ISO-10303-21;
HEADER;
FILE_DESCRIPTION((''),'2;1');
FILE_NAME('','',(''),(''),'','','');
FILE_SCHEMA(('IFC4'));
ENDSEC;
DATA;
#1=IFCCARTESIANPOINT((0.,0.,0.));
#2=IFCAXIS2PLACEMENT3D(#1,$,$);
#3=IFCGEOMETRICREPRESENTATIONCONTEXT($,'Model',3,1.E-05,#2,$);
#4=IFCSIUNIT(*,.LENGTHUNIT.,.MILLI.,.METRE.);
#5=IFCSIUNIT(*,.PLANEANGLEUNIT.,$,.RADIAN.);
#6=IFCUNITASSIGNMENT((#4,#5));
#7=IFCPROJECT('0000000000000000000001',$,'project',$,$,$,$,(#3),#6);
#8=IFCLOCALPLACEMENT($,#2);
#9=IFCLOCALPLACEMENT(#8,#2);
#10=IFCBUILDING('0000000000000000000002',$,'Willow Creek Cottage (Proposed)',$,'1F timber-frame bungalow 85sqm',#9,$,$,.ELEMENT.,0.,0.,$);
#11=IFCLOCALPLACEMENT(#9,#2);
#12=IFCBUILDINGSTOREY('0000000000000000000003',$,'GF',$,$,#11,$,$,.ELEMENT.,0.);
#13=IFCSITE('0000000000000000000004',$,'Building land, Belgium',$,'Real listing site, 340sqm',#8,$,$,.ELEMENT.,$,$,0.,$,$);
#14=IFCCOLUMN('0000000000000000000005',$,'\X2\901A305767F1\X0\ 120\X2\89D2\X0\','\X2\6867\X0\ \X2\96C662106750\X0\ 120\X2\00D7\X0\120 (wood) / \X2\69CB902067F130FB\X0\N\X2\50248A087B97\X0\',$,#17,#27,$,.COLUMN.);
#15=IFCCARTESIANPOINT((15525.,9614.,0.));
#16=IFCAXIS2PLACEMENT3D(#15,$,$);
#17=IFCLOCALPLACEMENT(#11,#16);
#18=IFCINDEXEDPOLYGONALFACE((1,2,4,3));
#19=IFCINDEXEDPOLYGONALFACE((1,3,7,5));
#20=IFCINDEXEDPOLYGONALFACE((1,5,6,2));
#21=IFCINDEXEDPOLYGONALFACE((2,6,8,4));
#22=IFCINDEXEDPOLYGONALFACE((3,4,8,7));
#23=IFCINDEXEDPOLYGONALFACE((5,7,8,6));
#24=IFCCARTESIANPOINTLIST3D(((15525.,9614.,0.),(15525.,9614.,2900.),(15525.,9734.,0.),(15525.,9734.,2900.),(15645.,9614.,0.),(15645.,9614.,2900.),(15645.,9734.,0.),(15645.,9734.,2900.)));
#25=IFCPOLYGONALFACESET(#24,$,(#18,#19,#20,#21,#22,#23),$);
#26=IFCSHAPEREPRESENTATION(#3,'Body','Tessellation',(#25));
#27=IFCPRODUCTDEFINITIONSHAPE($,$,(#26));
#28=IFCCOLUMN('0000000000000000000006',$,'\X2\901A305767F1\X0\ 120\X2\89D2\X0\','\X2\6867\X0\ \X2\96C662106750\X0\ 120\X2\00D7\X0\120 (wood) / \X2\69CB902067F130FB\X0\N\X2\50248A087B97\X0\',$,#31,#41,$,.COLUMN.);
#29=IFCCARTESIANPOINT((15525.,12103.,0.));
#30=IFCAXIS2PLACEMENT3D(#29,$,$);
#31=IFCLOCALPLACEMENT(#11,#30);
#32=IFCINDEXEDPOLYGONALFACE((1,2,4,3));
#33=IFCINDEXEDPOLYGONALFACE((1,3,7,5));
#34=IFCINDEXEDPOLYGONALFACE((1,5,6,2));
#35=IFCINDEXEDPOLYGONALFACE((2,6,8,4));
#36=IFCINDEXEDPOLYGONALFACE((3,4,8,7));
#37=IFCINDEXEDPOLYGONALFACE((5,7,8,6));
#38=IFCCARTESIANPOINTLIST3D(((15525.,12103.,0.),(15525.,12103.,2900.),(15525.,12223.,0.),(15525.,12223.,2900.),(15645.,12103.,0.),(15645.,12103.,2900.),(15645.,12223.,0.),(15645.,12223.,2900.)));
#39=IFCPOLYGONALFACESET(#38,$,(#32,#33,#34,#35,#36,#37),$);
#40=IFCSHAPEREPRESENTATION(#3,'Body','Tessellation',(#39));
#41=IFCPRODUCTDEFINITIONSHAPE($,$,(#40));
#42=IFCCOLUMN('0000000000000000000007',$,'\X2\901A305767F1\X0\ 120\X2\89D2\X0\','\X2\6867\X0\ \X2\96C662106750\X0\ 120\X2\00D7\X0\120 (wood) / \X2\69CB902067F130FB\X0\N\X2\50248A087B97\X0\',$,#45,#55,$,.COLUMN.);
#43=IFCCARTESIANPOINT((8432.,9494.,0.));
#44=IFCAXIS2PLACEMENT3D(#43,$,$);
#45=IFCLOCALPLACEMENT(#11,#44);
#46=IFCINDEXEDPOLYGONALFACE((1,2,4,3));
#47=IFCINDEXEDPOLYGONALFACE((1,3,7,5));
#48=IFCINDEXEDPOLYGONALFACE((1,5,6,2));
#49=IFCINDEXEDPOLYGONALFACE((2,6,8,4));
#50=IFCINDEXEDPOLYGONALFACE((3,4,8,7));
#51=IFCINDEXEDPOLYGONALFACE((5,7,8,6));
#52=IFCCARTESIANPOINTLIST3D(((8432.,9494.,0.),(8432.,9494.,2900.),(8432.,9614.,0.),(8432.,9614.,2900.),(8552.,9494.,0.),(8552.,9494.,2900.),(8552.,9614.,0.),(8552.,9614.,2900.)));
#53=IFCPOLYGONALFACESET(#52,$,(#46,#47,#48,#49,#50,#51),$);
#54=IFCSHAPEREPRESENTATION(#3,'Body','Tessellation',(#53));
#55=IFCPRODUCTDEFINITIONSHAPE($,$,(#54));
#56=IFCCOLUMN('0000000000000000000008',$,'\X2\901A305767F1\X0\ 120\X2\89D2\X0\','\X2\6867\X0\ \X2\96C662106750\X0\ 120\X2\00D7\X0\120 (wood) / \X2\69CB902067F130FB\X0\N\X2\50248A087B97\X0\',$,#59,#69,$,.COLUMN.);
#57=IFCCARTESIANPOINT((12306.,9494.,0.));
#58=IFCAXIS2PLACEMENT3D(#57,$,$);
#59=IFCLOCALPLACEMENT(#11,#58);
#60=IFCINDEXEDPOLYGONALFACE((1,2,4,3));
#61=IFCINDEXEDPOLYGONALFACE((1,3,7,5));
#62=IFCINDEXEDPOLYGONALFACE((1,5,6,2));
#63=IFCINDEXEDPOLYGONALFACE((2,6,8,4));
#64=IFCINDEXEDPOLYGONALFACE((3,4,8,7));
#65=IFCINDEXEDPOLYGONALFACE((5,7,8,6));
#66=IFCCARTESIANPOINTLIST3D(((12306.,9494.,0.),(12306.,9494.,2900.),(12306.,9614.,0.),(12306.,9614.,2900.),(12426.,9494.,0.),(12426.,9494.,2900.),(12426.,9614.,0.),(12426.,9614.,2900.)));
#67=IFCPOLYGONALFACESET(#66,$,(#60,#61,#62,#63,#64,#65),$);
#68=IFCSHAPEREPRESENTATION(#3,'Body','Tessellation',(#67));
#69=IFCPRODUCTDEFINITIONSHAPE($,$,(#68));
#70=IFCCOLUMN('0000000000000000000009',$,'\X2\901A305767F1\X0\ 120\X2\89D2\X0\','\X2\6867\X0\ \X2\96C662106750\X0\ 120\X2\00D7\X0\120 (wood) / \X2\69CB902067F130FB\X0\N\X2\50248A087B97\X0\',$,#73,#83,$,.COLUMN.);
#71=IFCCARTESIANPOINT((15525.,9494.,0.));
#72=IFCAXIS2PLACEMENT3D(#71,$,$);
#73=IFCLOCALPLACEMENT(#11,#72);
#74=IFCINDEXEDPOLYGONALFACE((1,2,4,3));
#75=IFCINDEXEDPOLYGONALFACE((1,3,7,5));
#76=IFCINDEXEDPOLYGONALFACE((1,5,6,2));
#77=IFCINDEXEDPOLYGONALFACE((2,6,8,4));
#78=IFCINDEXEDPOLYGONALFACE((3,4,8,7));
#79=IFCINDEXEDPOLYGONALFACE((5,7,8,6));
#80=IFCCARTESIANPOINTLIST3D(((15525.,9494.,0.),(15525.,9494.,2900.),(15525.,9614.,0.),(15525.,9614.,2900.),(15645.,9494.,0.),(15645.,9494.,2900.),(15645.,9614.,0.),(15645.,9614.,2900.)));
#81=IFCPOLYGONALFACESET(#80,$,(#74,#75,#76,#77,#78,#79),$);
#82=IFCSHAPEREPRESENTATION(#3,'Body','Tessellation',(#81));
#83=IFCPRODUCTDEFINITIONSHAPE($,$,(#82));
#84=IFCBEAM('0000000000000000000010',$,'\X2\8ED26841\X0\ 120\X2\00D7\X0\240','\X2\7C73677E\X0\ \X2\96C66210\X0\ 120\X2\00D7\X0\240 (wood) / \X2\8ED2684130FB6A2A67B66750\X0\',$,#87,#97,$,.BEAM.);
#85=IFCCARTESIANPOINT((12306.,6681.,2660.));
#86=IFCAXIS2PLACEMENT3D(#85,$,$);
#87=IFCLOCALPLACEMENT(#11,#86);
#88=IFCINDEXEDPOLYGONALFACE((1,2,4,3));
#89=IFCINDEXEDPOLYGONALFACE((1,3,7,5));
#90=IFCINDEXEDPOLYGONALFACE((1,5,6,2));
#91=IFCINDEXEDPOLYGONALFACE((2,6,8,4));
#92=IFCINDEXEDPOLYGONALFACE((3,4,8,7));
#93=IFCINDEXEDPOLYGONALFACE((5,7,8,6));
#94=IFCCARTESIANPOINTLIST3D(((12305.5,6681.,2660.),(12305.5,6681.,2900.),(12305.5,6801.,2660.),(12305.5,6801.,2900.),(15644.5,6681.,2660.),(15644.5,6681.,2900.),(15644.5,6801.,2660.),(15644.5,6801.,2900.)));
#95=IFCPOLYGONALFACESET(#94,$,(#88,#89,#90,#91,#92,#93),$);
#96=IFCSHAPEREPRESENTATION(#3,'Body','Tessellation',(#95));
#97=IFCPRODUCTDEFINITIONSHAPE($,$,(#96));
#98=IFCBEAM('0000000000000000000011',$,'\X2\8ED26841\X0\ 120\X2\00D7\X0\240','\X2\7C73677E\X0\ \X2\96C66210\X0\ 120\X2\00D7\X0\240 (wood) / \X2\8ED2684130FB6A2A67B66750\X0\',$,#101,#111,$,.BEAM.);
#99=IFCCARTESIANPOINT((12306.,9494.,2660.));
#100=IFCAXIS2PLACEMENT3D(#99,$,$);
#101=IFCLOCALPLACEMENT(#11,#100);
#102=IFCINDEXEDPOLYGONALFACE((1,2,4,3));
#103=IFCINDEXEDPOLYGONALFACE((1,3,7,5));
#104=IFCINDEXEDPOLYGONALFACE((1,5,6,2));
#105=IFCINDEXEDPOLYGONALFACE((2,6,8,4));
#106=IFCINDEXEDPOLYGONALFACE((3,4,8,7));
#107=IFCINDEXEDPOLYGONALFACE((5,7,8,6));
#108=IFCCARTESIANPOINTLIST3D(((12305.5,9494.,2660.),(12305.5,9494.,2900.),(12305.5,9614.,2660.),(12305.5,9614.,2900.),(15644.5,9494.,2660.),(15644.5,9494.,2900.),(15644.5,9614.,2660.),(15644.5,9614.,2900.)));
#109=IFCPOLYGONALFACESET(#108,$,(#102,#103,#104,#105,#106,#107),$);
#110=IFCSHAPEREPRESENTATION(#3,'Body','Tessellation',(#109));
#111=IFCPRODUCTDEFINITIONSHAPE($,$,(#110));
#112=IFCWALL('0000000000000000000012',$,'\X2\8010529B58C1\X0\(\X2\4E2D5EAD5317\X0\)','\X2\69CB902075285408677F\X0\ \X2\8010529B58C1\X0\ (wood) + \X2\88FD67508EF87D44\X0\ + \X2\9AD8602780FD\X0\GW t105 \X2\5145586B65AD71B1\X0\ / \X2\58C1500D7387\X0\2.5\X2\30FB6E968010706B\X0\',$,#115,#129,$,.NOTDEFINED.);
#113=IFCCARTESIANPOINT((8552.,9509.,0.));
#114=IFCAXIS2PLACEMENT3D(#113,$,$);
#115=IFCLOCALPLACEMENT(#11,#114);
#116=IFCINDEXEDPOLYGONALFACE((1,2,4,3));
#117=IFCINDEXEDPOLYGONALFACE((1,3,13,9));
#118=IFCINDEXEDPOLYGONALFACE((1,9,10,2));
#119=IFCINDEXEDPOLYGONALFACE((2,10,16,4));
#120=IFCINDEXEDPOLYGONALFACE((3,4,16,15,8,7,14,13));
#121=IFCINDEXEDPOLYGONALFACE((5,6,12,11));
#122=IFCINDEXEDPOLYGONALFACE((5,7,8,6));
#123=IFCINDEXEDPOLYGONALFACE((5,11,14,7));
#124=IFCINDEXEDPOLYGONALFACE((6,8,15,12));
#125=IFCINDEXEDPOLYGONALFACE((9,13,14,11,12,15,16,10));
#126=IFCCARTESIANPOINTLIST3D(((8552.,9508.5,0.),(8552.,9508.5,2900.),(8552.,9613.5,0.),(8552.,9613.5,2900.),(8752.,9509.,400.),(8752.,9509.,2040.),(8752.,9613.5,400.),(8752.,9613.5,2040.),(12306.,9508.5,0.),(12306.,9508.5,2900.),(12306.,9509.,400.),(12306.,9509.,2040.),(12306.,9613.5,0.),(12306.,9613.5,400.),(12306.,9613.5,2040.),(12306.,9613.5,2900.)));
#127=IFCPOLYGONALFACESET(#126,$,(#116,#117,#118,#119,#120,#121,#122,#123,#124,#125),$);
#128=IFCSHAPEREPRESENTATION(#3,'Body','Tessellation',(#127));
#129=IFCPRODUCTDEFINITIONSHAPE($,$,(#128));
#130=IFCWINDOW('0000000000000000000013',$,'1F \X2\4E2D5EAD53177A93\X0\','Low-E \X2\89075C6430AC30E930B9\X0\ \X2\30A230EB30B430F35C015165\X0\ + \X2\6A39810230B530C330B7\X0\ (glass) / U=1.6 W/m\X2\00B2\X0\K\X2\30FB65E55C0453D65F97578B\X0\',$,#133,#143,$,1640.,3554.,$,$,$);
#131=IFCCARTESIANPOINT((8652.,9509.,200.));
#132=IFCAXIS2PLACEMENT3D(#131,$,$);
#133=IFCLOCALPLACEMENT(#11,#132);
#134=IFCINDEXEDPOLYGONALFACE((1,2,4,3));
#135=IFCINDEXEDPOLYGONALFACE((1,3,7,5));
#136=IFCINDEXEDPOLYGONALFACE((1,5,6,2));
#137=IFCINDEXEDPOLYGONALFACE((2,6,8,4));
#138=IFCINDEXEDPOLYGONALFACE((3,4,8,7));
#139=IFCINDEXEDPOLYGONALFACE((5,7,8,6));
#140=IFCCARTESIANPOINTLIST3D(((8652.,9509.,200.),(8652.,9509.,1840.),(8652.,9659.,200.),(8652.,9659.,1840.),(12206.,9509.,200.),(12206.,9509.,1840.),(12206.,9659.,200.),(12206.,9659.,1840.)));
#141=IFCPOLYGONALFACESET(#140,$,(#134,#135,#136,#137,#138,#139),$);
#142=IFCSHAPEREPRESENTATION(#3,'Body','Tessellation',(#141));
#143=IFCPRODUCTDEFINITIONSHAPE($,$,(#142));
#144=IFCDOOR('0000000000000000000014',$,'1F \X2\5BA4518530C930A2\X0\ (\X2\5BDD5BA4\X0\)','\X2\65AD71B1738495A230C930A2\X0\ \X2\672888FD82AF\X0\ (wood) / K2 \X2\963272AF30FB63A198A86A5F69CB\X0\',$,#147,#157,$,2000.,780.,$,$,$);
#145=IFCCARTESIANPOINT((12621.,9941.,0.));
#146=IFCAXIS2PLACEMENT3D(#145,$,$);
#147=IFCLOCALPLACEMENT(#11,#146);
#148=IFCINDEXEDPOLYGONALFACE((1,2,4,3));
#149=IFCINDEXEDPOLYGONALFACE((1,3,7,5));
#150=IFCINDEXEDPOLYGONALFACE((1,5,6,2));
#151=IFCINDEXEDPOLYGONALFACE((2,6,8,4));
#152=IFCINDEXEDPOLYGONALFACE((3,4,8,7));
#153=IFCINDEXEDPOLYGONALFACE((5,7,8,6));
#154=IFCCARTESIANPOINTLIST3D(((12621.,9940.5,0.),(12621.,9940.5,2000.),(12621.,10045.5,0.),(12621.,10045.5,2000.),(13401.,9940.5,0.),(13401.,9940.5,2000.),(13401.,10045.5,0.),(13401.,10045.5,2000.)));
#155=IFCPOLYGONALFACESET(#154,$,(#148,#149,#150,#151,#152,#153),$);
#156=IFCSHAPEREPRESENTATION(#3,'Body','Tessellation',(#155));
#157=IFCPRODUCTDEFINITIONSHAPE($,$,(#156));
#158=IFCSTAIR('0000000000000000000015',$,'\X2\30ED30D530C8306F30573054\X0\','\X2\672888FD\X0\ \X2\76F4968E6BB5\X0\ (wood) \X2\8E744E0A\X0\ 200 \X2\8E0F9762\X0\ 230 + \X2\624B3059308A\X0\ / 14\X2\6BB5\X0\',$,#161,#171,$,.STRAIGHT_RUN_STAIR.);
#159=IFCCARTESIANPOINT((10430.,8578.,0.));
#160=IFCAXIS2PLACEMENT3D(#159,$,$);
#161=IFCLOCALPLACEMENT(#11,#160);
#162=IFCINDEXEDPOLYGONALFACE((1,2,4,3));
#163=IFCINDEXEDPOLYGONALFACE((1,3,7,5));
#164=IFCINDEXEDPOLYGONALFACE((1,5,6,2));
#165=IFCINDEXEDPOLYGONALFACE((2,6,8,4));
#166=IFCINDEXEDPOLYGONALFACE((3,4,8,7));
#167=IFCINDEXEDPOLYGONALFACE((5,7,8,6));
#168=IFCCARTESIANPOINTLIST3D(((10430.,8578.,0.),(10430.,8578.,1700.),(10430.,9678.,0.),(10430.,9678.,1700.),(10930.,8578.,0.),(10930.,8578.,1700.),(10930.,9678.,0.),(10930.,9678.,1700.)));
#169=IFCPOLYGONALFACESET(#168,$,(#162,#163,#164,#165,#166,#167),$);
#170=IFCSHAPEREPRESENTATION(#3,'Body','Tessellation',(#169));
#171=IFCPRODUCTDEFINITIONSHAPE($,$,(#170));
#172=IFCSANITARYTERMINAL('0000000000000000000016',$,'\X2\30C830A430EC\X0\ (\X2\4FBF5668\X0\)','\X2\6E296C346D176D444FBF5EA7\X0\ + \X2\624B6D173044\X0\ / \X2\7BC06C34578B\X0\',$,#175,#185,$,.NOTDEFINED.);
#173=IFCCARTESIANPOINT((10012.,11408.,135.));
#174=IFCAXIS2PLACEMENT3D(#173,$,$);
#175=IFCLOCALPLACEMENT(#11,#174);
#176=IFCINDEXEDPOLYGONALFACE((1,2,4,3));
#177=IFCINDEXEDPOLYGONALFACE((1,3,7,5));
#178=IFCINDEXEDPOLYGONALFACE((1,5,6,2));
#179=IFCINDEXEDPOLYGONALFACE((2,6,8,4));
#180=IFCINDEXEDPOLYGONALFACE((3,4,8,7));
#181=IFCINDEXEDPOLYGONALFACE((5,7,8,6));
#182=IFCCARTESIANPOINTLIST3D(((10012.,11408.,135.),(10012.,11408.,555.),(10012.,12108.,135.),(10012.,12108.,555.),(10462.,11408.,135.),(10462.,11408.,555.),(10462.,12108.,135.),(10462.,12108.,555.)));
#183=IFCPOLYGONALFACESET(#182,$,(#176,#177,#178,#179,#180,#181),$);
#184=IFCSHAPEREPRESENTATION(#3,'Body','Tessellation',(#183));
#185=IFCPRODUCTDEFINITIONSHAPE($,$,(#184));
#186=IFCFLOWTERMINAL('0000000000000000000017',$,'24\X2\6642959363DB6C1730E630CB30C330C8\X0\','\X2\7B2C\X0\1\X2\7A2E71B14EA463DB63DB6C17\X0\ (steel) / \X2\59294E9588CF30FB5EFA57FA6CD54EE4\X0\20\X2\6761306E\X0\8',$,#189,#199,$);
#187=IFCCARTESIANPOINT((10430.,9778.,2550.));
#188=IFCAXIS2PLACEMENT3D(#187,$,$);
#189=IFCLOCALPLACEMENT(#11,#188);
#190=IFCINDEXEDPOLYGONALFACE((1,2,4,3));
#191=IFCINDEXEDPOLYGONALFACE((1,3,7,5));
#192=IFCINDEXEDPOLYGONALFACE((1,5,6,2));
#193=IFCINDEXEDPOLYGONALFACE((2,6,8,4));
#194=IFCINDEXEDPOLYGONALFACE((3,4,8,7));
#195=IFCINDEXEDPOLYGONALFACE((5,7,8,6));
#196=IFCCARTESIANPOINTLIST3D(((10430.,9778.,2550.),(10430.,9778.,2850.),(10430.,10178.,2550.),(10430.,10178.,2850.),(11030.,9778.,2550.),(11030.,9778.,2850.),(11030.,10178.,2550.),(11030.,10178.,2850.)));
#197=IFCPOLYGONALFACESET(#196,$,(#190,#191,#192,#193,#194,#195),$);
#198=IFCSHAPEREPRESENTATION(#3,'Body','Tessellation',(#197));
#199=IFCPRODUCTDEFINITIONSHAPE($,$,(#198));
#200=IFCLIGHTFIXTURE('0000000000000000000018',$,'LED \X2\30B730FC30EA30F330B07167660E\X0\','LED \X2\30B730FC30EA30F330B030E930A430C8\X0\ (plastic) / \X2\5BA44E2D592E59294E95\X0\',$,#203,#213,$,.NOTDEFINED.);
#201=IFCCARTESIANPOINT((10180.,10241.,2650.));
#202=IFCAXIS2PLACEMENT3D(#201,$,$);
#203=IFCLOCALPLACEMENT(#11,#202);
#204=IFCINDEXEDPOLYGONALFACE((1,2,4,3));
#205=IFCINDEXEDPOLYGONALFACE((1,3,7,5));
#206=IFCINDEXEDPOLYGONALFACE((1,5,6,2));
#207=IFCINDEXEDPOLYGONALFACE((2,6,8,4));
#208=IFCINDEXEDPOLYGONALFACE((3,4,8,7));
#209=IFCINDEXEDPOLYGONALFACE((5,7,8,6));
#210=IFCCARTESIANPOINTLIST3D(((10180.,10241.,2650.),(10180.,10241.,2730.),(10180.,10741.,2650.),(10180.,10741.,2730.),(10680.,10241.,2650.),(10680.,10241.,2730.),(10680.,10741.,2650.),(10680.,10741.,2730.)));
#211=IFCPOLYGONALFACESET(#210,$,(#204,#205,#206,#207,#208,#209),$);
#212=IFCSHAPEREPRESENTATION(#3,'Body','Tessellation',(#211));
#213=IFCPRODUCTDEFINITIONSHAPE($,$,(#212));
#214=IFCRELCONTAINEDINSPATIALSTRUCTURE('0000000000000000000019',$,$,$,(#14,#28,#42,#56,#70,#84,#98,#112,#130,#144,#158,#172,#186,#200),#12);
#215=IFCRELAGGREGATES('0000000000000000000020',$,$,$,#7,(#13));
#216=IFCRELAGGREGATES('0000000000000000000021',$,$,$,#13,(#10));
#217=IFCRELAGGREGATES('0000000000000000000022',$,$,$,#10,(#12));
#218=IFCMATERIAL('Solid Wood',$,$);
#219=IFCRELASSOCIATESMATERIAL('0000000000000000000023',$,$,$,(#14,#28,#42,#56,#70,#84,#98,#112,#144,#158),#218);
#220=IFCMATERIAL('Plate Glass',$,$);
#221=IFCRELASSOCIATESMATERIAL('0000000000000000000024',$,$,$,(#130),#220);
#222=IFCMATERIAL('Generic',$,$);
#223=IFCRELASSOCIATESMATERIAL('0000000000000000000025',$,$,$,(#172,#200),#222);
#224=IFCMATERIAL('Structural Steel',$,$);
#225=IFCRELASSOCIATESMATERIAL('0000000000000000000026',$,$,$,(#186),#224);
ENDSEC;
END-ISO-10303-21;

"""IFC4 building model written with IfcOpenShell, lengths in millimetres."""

from ifc_helpers import new_model, si_unit, frame, frame_2d, origin, place, context, project, spatial, rectangle, extrude, material, element, fill, save


model = new_model("IFC4")

# Units and contexts
model_context = context("Model", 3, precision=1e-05, world=origin())
ifc_project = project(units=[si_unit("LENGTHUNIT", "METRE", prefix="MILLI"), si_unit("PLANEANGLEUNIT", "RADIAN")], contexts=[model_context])

# Site, building, storey
site_placement = place(None, origin())
site = spatial("IfcSite", under=ifc_project, at=site_placement, Name="Building land, Belgium", ObjectType="Real listing site, 340sqm", CompositionType="ELEMENT", RefElevation=0.0)
building_placement = place(site_placement, origin())
building = spatial("IfcBuilding", under=site, at=building_placement, Name="Willow Creek Cottage (Proposed)", ObjectType="1F timber-frame bungalow 85sqm", CompositionType="ELEMENT", ElevationOfRefHeight=0.0, ElevationOfTerrain=0.0)
storey_placement = place(building_placement, origin())
storey = spatial("IfcBuildingStorey", under=building, at=storey_placement, Name="GF", CompositionType="ELEMENT", Elevation=0.0)

# Columns
ifc_material_1 = material(Name="Solid Wood")
column_1_placement = place(storey_placement, frame((15525.0, 9614.0, 0.0)))
element("IfcColumn", 1, at=column_1_placement, inside=storey, material=ifc_material_1, Name="通し柱 120角", Description="桧 集成材 120×120 (wood) / 構造柱・N値計算", PredefinedType="COLUMN", context=model_context, shape_type="SweptSolid", body=[
    extrude(rectangle(XDim=120.0, YDim=120.0, at=frame_2d((60.0, 60.0))), frame((15525.0, 9614.0, 0.0)), (0.0, 0.0, 1.0), 2900.0),
])
column_2_placement = place(storey_placement, frame((15525.0, 12103.0, 0.0)))
element("IfcColumn", 2, at=column_2_placement, inside=storey, material=ifc_material_1, Name="通し柱 120角", Description="桧 集成材 120×120 (wood) / 構造柱・N値計算", PredefinedType="COLUMN", context=model_context, shape_type="SweptSolid", body=[
    extrude(rectangle(XDim=120.0, YDim=120.0, at=frame_2d((60.0, 60.0))), frame((15525.0, 12103.0, 0.0)), (0.0, 0.0, 1.0), 2900.0),
])
column_3_placement = place(storey_placement, frame((8432.0, 9494.0, 0.0)))
element("IfcColumn", 3, at=column_3_placement, inside=storey, material=ifc_material_1, Name="通し柱 120角", Description="桧 集成材 120×120 (wood) / 構造柱・N値計算", PredefinedType="COLUMN", context=model_context, shape_type="SweptSolid", body=[
    extrude(rectangle(XDim=120.0, YDim=120.0, at=frame_2d((60.0, 60.0))), frame((8432.0, 9494.0, 0.0)), (0.0, 0.0, 1.0), 2900.0),
])
column_4_placement = place(storey_placement, frame((12306.0, 9494.0, 0.0)))
element("IfcColumn", 4, at=column_4_placement, inside=storey, material=ifc_material_1, Name="通し柱 120角", Description="桧 集成材 120×120 (wood) / 構造柱・N値計算", PredefinedType="COLUMN", context=model_context, shape_type="SweptSolid", body=[
    extrude(rectangle(XDim=120.0, YDim=120.0, at=frame_2d((60.0, 60.0))), frame((12306.0, 9494.0, 0.0)), (0.0, 0.0, 1.0), 2900.0),
])
column_5_placement = place(storey_placement, frame((15525.0, 9494.0, 0.0)))
element("IfcColumn", 5, at=column_5_placement, inside=storey, material=ifc_material_1, Name="通し柱 120角", Description="桧 集成材 120×120 (wood) / 構造柱・N値計算", PredefinedType="COLUMN", context=model_context, shape_type="SweptSolid", body=[
    extrude(rectangle(XDim=120.0, YDim=120.0, at=frame_2d((60.0, 60.0))), frame((15525.0, 9494.0, 0.0)), (0.0, 0.0, 1.0), 2900.0),
])

# Beams
beam_1_placement = place(storey_placement, frame((12306.0, 6681.0, 2660.0)))
element("IfcBeam", 6, at=beam_1_placement, inside=storey, material=ifc_material_1, Name="軒桁 120×240", Description="米松 集成 120×240 (wood) / 軒桁・横架材", PredefinedType="BEAM", context=model_context, shape_type="SweptSolid", body=[
    extrude(rectangle(XDim=3339.0, YDim=120.0, at=frame_2d((1669.0, 60.0))), frame((12306.0, 6681.0, 2660.0)), (0.0, 0.0, 1.0), 240.0),
])
beam_2_placement = place(storey_placement, frame((12306.0, 9494.0, 2660.0)))
element("IfcBeam", 7, at=beam_2_placement, inside=storey, material=ifc_material_1, Name="軒桁 120×240", Description="米松 集成 120×240 (wood) / 軒桁・横架材", PredefinedType="BEAM", context=model_context, shape_type="SweptSolid", body=[
    extrude(rectangle(XDim=3339.0, YDim=120.0, at=frame_2d((1669.0, 60.0))), frame((12306.0, 9494.0, 2660.0)), (0.0, 0.0, 1.0), 240.0),
])

# Wall, opening, window
wall_1_placement = place(storey_placement, frame((8552.0, 9509.0, 0.0)))
wall_1 = element("IfcWall", 8, at=wall_1_placement, inside=storey, material=ifc_material_1, Name="耐力壁(中庭北)", Description="構造用合板 耐力壁 (wood) + 製材軸組 + 高性能GW t105 充填断熱 / 壁倍率2.5・準耐火", PredefinedType="NOTDEFINED", context=model_context, shape_type="SweptSolid", body=[
    extrude(rectangle(XDim=3754.0, YDim=105.0, at=frame_2d((1877.0, 52.0))), frame((8552.0, 9509.0, 0.0)), (0.0, 0.0, 1.0), 2900.0),
])
opening_placement = place(storey_placement, frame((8652.0, 9509.0, 200.0)))
opening = element("IfcOpeningElement", 9, at=opening_placement, cuts=wall_1, PredefinedType="NOTDEFINED", context=model_context, shape_type="SweptSolid", body=[
    extrude(rectangle(XDim=3554.0, YDim=150.0, at=frame_2d((1777.0, 75.0))), frame((8652.0, 9509.0, 200.0)), (0.0, 0.0, 1.0), 1640.0),
])
ifc_material_2 = material(Name="Plate Glass")
window_placement = place(storey_placement, frame((8652.0, 9509.0, 200.0)))
window = element("IfcWindow", 10, at=window_placement, inside=storey, material=ifc_material_2, Name="1F 中庭北窓", Description="Low-E 複層ガラス アルゴン封入 + 樹脂サッシ (glass) / U=1.6 W/m²K・日射取得型", OverallHeight=1640.0, OverallWidth=3554.0, context=model_context, shape_type="SweptSolid", body=[
    extrude(rectangle(XDim=3554.0, YDim=150.0, at=frame_2d((1777.0, 75.0))), frame((8652.0, 9509.0, 200.0)), (0.0, 0.0, 1.0), 1640.0),
])
fill(opening, window)

# Door
door_placement = place(storey_placement, frame((12621.0, 9941.0, 0.0)))
element("IfcDoor", 11, at=door_placement, inside=storey, material=ifc_material_1, Name="1F 室内ドア (寝室)", Description="断熱玄関ドア 木製芯 (wood) / K2 防犯・採風機構", OverallHeight=2000.0, OverallWidth=780.0, context=model_context, shape_type="SweptSolid", body=[
    extrude(rectangle(XDim=780.0, YDim=105.0, at=frame_2d((390.0, 52.0))), frame((12621.0, 9941.0, 0.0)), (0.0, 0.0, 1.0), 2000.0),
])

# Stair
stair_placement = place(storey_placement, frame((10430.0, 8578.0, 0.0)))
element("IfcStair", 12, at=stair_placement, inside=storey, material=ifc_material_1, Name="ロフトはしご", Description="木製 直階段 (wood) 蹴上 200 踏面 230 + 手すり / 14段", PredefinedType="STRAIGHT_RUN_STAIR", context=model_context, shape_type="SweptSolid", body=[
    extrude(rectangle(XDim=500.0, YDim=1100.0, at=frame_2d((250.0, 550.0))), frame((10430.0, 8578.0, 0.0)), (0.0, 0.0, 1.0), 1700.0),
])

# Shared definitions
ifc_material_3 = material(Name="Generic")

# Sanitary terminal
sanitary_terminal_placement = place(storey_placement, frame((10012.0, 11408.0, 135.0)))
element("IfcSanitaryTerminal", 13, at=sanitary_terminal_placement, inside=storey, material=ifc_material_3, Name="トイレ (便器)", Description="温水洗浄便座 + 手洗い / 節水型", PredefinedType="NOTDEFINED", context=model_context, shape_type="SweptSolid", body=[
    extrude(rectangle(XDim=450.0, YDim=700.0, at=frame_2d((225.0, 350.0))), frame((10012.0, 11408.0, 135.0)), (0.0, 0.0, 1.0), 420.0),
])

# Flow terminal
ifc_material_4 = material(Name="Structural Steel")
flow_terminal_placement = place(storey_placement, frame((10430.0, 9778.0, 2550.0)))
element("IfcFlowTerminal", 14, at=flow_terminal_placement, inside=storey, material=ifc_material_4, Name="24時間換気ユニット", Description="第1種熱交換換気 (steel) / 天井裏・建基法令20条の8", context=model_context, shape_type="SweptSolid", body=[
    extrude(rectangle(XDim=600.0, YDim=400.0, at=frame_2d((300.0, 200.0))), frame((10430.0, 9778.0, 2550.0)), (0.0, 0.0, 1.0), 300.0),
])

# Light fixture
light_fixture_1_placement = place(storey_placement, frame((10180.0, 10241.0, 2650.0)))
element("IfcLightFixture", 15, at=light_fixture_1_placement, inside=storey, material=ifc_material_3, Name="LED シーリング照明", Description="LED シーリングライト (plastic) / 室中央天井", PredefinedType="NOTDEFINED", context=model_context, shape_type="SweptSolid", body=[
    extrude(rectangle(XDim=500.0, YDim=500.0, at=frame_2d((250.0, 250.0))), frame((10180.0, 10241.0, 2650.0)), (0.0, 0.0, 1.0), 80.0),
])

save(model, "model.ifc")
